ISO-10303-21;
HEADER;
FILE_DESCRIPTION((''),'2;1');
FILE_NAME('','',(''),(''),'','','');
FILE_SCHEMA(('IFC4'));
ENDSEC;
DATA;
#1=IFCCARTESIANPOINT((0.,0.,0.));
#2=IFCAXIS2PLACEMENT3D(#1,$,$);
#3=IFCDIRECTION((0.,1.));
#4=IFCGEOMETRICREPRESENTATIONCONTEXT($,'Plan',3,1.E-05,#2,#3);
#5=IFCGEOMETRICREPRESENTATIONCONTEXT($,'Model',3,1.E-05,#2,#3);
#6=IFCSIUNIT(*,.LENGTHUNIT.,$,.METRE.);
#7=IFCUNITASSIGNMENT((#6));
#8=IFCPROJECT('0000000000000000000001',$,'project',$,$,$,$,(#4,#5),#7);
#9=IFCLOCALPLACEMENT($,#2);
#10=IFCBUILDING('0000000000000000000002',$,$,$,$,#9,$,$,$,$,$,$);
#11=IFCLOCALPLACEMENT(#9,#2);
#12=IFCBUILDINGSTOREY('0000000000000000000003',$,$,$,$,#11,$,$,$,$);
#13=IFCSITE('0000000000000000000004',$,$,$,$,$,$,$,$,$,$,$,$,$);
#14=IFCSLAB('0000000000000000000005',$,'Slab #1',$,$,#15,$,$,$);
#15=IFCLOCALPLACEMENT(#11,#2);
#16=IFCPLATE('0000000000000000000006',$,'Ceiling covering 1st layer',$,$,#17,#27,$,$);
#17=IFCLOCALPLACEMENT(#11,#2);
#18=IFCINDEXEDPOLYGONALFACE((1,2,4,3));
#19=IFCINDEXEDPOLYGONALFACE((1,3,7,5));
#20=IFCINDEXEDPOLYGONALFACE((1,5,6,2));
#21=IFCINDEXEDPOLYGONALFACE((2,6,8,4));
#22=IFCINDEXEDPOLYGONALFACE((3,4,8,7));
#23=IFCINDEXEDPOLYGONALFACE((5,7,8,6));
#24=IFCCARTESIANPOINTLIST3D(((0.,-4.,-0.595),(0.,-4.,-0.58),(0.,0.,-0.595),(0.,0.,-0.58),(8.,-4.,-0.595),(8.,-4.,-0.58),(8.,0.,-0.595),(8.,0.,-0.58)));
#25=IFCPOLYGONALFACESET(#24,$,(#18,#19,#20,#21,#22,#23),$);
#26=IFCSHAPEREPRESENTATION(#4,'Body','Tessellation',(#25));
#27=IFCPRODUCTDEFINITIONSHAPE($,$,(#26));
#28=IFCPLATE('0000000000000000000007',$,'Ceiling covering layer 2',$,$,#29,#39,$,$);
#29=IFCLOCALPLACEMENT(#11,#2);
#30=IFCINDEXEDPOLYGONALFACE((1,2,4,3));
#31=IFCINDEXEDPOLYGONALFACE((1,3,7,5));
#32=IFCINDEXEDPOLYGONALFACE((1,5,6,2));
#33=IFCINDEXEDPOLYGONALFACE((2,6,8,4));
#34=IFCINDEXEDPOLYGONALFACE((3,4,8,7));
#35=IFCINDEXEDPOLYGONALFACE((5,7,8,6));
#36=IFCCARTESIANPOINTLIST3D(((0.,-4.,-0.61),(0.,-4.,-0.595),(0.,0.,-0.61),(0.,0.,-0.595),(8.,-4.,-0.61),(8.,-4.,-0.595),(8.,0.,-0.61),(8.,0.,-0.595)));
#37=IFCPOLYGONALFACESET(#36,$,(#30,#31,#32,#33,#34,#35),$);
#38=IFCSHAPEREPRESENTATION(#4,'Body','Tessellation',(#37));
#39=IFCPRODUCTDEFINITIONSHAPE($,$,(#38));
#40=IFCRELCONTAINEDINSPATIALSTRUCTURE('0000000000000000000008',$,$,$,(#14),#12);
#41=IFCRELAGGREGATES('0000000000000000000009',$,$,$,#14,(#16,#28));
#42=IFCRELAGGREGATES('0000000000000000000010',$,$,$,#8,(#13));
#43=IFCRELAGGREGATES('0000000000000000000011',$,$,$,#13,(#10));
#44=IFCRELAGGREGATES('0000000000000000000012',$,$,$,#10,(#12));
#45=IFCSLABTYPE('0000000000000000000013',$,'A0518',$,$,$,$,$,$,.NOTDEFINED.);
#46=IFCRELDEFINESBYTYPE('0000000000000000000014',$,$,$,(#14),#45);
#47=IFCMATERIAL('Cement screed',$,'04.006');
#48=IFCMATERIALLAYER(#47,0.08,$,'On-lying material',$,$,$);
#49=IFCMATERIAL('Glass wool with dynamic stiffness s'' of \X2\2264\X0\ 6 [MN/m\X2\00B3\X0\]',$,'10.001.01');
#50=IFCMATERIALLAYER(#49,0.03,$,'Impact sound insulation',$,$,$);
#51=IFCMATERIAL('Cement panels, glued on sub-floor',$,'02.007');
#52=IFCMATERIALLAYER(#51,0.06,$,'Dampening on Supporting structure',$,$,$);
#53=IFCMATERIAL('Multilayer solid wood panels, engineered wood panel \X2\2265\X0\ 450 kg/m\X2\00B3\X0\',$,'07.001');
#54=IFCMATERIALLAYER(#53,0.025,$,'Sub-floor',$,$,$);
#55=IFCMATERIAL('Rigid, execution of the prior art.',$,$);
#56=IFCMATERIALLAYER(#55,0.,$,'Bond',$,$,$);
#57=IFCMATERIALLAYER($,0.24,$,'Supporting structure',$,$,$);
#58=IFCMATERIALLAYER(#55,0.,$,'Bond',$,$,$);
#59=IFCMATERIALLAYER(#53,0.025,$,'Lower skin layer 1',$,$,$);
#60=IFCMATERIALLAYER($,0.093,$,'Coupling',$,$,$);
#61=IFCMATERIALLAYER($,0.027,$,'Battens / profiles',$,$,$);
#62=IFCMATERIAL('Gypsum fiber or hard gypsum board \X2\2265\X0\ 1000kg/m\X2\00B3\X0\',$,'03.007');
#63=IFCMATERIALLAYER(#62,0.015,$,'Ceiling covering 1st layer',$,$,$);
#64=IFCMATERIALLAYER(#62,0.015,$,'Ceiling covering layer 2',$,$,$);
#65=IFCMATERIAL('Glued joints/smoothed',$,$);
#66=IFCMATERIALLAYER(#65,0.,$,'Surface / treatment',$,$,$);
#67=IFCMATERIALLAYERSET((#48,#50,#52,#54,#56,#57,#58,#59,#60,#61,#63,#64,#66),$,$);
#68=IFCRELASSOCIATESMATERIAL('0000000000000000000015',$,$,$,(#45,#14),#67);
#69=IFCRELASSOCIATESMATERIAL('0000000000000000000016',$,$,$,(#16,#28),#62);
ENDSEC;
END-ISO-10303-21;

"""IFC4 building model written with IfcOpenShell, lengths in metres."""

from ifc_helpers import new_model, si_unit, direction, frame, frame_2d, origin, place, context, project, spatial, rectangle, extrude, material, layer, layer_set, type_object, element, aggregate, save


model = new_model("IFC4")

# Units and contexts
plan_context = context("Plan", 3, precision=1e-05, world=origin(), true_north=direction((0.0, 1.0)))
model_context = context("Model", 3, precision=1e-05, world=origin(), true_north=direction((0.0, 1.0)))
ifc_project = project(units=[si_unit("LENGTHUNIT", "METRE")], contexts=[plan_context, model_context])

# Site, building, storey
site = spatial("IfcSite", under=ifc_project)
building_placement = place(None, origin())
building = spatial("IfcBuilding", under=site, at=building_placement)
storey_placement = place(building_placement, origin())
storey = spatial("IfcBuildingStorey", under=building, at=storey_placement)

# Slab, plates
ifc_material_1 = material(Name="Cement screed", Category="04.006")
ifc_layer_1 = layer(ifc_material_1, 0.08, Name="On-lying material")
ifc_material_2 = material(Name="Glass wool with dynamic stiffness s' of ≤ 6 [MN/m³]", Category="10.001.01")
ifc_layer_2 = layer(ifc_material_2, 0.03, Name="Impact sound insulation")
ifc_material_3 = material(Name="Cement panels, glued on sub-floor", Category="02.007")
ifc_layer_3 = layer(ifc_material_3, 0.06, Name="Dampening on Supporting structure")
ifc_material_4 = material(Name="Multilayer solid wood panels, engineered wood panel ≥ 450 kg/m³", Category="07.001")
ifc_layer_4 = layer(ifc_material_4, 0.025, Name="Sub-floor")
ifc_material_5 = material(Name="Rigid, execution of the prior art.")
ifc_layer_5 = layer(ifc_material_5, 0.0, Name="Bond")
ifc_layer_6 = layer(None, 0.24, Name="Supporting structure")
ifc_layer_7 = layer(ifc_material_5, 0.0, Name="Bond")
ifc_layer_8 = layer(ifc_material_4, 0.025, Name="Lower skin layer 1")
ifc_layer_9 = layer(None, 0.093, Name="Coupling")
ifc_layer_10 = layer(None, 0.027, Name="Battens / profiles")
ifc_material_6 = material(Name="Gypsum fiber or hard gypsum board ≥ 1000kg/m³", Category="03.007")
ifc_layer_11 = layer(ifc_material_6, 0.015, Name="Ceiling covering 1st layer")
ifc_layer_12 = layer(ifc_material_6, 0.015, Name="Ceiling covering layer 2")
ifc_material_7 = material(Name="Glued joints/smoothed")
ifc_layer_13 = layer(ifc_material_7, 0.0, Name="Surface / treatment")
ifc_layer_set = layer_set([ifc_layer_1, ifc_layer_2, ifc_layer_3, ifc_layer_4, ifc_layer_5, ifc_layer_6, ifc_layer_7, ifc_layer_8, ifc_layer_9, ifc_layer_10, ifc_layer_11, ifc_layer_12, ifc_layer_13])
slab_type = type_object("IfcSlabType", Name="A0518", PredefinedType="NOTDEFINED", material=ifc_layer_set)
slab_placement = place(None, frame((0.0, 0.0, 0.0), z_axis=(0.0, 0.0, -1.0), x_axis=(1.0, 0.0, 0.0)))
slab = element("IfcSlab", 1, at=slab_placement, inside=storey, type_object=slab_type, material=ifc_layer_set, Name="Slab #1")
plate_1_placement = place(slab_placement, origin())
plate_1 = element("IfcPlate", 2, at=plate_1_placement, material=ifc_material_6, Name="Ceiling covering 1st layer", context=plan_context, shape_type="SweptSolid", body=[
    extrude(rectangle(XDim=8.0, YDim=4.0, at=frame_2d((4.0, 2.0), x_axis=(1.0, 0.0))), frame((0.0, 0.0, 0.58), z_axis=(0.0, 0.0, 1.0), x_axis=(1.0, 0.0, 0.0)), (0.0, 0.0, 1.0), 0.015),
])
plate_2_placement = place(slab_placement, origin())
plate_2 = element("IfcPlate", 3, at=plate_2_placement, material=ifc_material_6, Name="Ceiling covering layer 2", context=plan_context, shape_type="SweptSolid", body=[
    extrude(rectangle(XDim=8.0, YDim=4.0, at=frame_2d((4.0, 2.0), x_axis=(1.0, 0.0))), frame((0.0, 0.0, 0.595), z_axis=(0.0, 0.0, 1.0), x_axis=(1.0, 0.0, 0.0)), (0.0, 0.0, 1.0), 0.015),
])
aggregate(slab, [plate_1, plate_2])

save(model, "model.ifc")
